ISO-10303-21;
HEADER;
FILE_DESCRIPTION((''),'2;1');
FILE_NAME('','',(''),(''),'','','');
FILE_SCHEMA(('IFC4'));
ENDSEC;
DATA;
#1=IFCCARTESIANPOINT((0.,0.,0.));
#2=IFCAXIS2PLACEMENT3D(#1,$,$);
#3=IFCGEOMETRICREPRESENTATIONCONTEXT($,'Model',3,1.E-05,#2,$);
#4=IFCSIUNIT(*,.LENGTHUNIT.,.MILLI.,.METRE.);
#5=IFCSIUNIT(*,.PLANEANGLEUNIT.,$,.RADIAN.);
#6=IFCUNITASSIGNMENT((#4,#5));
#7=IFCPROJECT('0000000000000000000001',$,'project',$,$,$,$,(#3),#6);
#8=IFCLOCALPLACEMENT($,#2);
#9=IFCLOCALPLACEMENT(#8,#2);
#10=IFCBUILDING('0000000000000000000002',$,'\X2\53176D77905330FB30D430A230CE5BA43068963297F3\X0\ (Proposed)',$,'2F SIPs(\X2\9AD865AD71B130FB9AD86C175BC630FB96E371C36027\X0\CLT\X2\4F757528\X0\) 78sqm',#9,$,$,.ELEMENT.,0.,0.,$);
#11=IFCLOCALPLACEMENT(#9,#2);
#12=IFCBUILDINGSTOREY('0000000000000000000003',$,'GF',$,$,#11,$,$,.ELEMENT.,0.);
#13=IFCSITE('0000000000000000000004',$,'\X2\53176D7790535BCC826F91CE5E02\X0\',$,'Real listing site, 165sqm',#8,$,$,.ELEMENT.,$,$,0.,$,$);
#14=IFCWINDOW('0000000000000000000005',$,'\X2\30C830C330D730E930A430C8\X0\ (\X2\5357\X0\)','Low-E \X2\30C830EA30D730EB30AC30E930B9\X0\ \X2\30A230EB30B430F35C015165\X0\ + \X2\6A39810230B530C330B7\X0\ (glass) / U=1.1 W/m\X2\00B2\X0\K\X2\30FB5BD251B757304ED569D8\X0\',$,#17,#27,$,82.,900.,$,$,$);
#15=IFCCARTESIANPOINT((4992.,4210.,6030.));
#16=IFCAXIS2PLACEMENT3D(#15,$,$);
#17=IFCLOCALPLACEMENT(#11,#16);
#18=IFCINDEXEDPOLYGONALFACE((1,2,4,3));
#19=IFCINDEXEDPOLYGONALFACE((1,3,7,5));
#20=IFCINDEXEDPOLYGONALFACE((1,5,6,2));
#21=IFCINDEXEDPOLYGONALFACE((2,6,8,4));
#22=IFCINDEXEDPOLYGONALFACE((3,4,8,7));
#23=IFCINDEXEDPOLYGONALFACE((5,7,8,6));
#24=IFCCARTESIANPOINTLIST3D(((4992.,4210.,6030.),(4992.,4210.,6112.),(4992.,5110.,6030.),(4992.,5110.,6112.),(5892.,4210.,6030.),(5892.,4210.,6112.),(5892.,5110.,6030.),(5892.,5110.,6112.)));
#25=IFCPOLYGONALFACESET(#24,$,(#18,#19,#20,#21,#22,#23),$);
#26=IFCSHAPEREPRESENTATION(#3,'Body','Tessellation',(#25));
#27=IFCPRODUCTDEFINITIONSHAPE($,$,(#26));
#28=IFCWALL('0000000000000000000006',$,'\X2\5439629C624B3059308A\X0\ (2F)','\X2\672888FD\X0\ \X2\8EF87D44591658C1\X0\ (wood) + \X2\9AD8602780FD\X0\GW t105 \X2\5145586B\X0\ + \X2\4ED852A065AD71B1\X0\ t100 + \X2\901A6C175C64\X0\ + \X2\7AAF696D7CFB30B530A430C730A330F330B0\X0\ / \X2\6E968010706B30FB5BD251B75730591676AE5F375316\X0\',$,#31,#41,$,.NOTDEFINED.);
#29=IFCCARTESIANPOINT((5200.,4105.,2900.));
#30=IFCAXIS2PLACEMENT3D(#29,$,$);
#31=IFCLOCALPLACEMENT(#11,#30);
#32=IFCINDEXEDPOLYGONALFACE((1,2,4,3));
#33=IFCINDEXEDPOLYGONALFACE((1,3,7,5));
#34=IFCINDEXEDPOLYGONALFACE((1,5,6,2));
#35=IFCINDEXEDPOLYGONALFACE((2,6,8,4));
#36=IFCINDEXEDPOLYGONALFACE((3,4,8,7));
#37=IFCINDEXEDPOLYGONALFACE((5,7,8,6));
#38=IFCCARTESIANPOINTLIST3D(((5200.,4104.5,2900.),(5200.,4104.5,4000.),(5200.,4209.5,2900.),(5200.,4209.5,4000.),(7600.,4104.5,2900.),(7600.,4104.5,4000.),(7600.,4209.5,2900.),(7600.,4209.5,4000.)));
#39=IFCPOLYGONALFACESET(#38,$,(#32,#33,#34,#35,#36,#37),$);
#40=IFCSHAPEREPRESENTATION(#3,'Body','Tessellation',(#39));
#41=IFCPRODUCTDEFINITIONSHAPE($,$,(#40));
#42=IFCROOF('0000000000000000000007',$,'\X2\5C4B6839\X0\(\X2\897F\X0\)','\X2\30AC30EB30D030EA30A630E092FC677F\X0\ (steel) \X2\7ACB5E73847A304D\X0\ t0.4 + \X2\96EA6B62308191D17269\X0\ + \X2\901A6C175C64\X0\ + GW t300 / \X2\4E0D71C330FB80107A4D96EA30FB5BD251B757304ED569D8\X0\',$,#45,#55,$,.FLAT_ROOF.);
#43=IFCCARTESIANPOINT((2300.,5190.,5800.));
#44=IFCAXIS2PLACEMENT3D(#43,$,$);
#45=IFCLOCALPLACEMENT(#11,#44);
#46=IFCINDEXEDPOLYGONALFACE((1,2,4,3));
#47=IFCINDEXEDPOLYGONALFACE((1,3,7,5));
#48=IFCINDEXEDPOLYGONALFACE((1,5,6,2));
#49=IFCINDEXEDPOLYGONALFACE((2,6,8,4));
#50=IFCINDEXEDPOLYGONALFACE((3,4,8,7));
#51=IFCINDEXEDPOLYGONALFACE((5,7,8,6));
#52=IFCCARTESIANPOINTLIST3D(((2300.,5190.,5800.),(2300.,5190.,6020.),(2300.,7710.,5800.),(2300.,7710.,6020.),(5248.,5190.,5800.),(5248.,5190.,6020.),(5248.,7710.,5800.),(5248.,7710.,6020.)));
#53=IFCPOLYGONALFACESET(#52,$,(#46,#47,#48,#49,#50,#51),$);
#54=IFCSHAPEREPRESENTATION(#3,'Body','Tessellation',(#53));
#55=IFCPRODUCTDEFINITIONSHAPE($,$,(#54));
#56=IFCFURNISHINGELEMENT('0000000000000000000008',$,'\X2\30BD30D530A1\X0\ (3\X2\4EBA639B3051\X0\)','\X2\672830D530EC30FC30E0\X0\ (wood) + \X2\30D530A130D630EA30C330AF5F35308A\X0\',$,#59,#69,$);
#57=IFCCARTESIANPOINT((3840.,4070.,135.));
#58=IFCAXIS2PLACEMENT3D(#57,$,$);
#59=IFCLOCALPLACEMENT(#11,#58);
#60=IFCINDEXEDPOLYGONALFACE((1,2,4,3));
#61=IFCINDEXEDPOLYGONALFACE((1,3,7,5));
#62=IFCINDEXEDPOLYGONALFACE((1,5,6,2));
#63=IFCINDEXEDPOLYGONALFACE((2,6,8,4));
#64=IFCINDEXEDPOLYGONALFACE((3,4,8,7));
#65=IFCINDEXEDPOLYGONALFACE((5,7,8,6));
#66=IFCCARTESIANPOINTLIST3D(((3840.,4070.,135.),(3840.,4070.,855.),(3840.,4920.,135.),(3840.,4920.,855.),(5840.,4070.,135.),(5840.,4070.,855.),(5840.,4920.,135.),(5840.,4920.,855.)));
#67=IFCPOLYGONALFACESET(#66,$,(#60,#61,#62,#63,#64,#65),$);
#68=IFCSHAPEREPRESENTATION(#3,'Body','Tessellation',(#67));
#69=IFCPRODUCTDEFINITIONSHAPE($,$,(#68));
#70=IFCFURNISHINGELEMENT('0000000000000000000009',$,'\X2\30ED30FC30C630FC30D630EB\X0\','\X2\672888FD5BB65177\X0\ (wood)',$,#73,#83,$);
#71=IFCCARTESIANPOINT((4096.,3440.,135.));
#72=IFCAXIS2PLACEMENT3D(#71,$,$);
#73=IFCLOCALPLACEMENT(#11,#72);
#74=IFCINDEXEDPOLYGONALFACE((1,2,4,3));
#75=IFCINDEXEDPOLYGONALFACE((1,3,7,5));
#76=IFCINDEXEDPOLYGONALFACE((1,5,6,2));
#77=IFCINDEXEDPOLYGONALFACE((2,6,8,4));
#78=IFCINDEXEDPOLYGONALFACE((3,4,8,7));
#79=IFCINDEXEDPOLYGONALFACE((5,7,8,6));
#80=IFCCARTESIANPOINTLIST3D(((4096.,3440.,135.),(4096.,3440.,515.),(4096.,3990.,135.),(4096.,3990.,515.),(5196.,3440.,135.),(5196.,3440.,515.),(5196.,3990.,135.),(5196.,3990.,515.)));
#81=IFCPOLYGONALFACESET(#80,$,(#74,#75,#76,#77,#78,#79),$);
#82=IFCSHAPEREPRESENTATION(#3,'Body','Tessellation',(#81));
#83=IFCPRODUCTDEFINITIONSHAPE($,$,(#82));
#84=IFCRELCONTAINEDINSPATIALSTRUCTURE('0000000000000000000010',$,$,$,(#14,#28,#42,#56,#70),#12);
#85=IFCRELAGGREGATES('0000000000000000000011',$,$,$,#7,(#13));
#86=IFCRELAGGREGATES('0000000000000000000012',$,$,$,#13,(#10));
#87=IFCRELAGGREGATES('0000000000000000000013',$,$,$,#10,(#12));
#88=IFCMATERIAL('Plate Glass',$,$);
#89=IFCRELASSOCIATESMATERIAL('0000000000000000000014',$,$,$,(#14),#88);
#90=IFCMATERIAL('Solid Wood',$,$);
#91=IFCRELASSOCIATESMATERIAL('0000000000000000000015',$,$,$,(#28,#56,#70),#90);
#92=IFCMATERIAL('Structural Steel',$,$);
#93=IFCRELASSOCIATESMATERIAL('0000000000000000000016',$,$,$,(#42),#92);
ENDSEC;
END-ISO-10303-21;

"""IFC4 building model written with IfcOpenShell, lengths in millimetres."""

from ifc_helpers import new_model, si_unit, frame, frame_2d, origin, place, context, project, spatial, rectangle, extrude, material, element, save


model = new_model("IFC4")

# Units and contexts
model_context = context("Model", 3, precision=1e-05, world=origin())
ifc_project = project(units=[si_unit("LENGTHUNIT", "METRE", prefix="MILLI"), si_unit("PLANEANGLEUNIT", "RADIAN")], contexts=[model_context])

# Site, building, storey
site_placement = place(None, origin())
site = spatial("IfcSite", under=ifc_project, at=site_placement, Name="北海道富良野市", ObjectType="Real listing site, 165sqm", CompositionType="ELEMENT", RefElevation=0.0)
building_placement = place(site_placement, origin())
building = spatial("IfcBuilding", under=site, at=building_placement, Name="北海道・ピアノ室と防音 (Proposed)", ObjectType="2F SIPs(高断熱・高気密・難燃性CLT併用) 78sqm", CompositionType="ELEMENT", ElevationOfRefHeight=0.0, ElevationOfTerrain=0.0)
storey_placement = place(building_placement, origin())
storey = spatial("IfcBuildingStorey", under=building, at=storey_placement, Name="GF", CompositionType="ELEMENT", Elevation=0.0)

# Shared definitions
ifc_material_1 = material(Name="Solid Wood")

# Window
ifc_material_2 = material(Name="Plate Glass")
window_placement = place(storey_placement, frame((4992.0, 4210.0, 6030.0)))
element("IfcWindow", 1, at=window_placement, inside=storey, material=ifc_material_2, Name="トップライト (南)", Description="Low-E トリプルガラス アルゴン封入 + 樹脂サッシ (glass) / U=1.1 W/m²K・寒冷地仕様", OverallHeight=82.0, OverallWidth=900.0, context=model_context, shape_type="SweptSolid", body=[
    extrude(rectangle(XDim=900.0, YDim=900.0, at=frame_2d((450.0, 450.0))), frame((4992.0, 4210.0, 6030.0)), (0.0, 0.0, 1.0), 82.0),
])

# Wall
wall_placement = place(storey_placement, frame((5200.0, 4105.0, 2900.0)))
element("IfcWall", 2, at=wall_placement, inside=storey, material=ifc_material_1, Name="吹抜手すり (2F)", Description="木製 軸組外壁 (wood) + 高性能GW t105 充填 + 付加断熱 t100 + 通気層 + 窯業系サイディング / 準耐火・寒冷地外皮強化", PredefinedType="NOTDEFINED", context=model_context, shape_type="SweptSolid", body=[
    extrude(rectangle(XDim=2400.0, YDim=105.0, at=frame_2d((1200.0, 52.0))), frame((5200.0, 4105.0, 2900.0)), (0.0, 0.0, 1.0), 1100.0),
])

# Roof
ifc_material_3 = material(Name="Structural Steel")
for number, where, name in (
    (3, (2300.0, 5190.0, 5800.0), "屋根(西)"),
):
    element("IfcRoof", number, at=place(storey_placement, frame(where)), inside=storey, material=ifc_material_3, Name=name, Description="ガルバリウム鋼板 (steel) 立平葺き t0.4 + 雪止め金物 + 通気層 + GW t300 / 不燃・耐積雪・寒冷地仕様", PredefinedType="FLAT_ROOF", context=model_context, shape_type="SweptSolid", body=[
        extrude(rectangle(XDim=2948.0, YDim=2520.0, at=frame_2d((1474.0, 1260.0))), frame((2300.0, 5190.0, 5800.0)), (0.0, 0.0, 1.0), 220.0),
    ])

# Furnishing elements
furnishing_1_placement = place(storey_placement, frame((3840.0, 4070.0, 135.0)))
element("IfcFurnishingElement", 4, at=furnishing_1_placement, inside=storey, material=ifc_material_1, Name="ソファ (3人掛け)", Description="木フレーム (wood) + ファブリック張り", context=model_context, shape_type="SweptSolid", body=[
    extrude(rectangle(XDim=2000.0, YDim=850.0, at=frame_2d((1000.0, 425.0))), frame((3840.0, 4070.0, 135.0)), (0.0, 0.0, 1.0), 720.0),
])
furnishing_2_placement = place(storey_placement, frame((4096.0, 3440.0, 135.0)))
element("IfcFurnishingElement", 5, at=furnishing_2_placement, inside=storey, material=ifc_material_1, Name="ローテーブル", Description="木製家具 (wood)", context=model_context, shape_type="SweptSolid", body=[
    extrude(rectangle(XDim=1100.0, YDim=550.0, at=frame_2d((550.0, 275.0))), frame((4096.0, 3440.0, 135.0)), (0.0, 0.0, 1.0), 380.0),
])

save(model, "model.ifc")
